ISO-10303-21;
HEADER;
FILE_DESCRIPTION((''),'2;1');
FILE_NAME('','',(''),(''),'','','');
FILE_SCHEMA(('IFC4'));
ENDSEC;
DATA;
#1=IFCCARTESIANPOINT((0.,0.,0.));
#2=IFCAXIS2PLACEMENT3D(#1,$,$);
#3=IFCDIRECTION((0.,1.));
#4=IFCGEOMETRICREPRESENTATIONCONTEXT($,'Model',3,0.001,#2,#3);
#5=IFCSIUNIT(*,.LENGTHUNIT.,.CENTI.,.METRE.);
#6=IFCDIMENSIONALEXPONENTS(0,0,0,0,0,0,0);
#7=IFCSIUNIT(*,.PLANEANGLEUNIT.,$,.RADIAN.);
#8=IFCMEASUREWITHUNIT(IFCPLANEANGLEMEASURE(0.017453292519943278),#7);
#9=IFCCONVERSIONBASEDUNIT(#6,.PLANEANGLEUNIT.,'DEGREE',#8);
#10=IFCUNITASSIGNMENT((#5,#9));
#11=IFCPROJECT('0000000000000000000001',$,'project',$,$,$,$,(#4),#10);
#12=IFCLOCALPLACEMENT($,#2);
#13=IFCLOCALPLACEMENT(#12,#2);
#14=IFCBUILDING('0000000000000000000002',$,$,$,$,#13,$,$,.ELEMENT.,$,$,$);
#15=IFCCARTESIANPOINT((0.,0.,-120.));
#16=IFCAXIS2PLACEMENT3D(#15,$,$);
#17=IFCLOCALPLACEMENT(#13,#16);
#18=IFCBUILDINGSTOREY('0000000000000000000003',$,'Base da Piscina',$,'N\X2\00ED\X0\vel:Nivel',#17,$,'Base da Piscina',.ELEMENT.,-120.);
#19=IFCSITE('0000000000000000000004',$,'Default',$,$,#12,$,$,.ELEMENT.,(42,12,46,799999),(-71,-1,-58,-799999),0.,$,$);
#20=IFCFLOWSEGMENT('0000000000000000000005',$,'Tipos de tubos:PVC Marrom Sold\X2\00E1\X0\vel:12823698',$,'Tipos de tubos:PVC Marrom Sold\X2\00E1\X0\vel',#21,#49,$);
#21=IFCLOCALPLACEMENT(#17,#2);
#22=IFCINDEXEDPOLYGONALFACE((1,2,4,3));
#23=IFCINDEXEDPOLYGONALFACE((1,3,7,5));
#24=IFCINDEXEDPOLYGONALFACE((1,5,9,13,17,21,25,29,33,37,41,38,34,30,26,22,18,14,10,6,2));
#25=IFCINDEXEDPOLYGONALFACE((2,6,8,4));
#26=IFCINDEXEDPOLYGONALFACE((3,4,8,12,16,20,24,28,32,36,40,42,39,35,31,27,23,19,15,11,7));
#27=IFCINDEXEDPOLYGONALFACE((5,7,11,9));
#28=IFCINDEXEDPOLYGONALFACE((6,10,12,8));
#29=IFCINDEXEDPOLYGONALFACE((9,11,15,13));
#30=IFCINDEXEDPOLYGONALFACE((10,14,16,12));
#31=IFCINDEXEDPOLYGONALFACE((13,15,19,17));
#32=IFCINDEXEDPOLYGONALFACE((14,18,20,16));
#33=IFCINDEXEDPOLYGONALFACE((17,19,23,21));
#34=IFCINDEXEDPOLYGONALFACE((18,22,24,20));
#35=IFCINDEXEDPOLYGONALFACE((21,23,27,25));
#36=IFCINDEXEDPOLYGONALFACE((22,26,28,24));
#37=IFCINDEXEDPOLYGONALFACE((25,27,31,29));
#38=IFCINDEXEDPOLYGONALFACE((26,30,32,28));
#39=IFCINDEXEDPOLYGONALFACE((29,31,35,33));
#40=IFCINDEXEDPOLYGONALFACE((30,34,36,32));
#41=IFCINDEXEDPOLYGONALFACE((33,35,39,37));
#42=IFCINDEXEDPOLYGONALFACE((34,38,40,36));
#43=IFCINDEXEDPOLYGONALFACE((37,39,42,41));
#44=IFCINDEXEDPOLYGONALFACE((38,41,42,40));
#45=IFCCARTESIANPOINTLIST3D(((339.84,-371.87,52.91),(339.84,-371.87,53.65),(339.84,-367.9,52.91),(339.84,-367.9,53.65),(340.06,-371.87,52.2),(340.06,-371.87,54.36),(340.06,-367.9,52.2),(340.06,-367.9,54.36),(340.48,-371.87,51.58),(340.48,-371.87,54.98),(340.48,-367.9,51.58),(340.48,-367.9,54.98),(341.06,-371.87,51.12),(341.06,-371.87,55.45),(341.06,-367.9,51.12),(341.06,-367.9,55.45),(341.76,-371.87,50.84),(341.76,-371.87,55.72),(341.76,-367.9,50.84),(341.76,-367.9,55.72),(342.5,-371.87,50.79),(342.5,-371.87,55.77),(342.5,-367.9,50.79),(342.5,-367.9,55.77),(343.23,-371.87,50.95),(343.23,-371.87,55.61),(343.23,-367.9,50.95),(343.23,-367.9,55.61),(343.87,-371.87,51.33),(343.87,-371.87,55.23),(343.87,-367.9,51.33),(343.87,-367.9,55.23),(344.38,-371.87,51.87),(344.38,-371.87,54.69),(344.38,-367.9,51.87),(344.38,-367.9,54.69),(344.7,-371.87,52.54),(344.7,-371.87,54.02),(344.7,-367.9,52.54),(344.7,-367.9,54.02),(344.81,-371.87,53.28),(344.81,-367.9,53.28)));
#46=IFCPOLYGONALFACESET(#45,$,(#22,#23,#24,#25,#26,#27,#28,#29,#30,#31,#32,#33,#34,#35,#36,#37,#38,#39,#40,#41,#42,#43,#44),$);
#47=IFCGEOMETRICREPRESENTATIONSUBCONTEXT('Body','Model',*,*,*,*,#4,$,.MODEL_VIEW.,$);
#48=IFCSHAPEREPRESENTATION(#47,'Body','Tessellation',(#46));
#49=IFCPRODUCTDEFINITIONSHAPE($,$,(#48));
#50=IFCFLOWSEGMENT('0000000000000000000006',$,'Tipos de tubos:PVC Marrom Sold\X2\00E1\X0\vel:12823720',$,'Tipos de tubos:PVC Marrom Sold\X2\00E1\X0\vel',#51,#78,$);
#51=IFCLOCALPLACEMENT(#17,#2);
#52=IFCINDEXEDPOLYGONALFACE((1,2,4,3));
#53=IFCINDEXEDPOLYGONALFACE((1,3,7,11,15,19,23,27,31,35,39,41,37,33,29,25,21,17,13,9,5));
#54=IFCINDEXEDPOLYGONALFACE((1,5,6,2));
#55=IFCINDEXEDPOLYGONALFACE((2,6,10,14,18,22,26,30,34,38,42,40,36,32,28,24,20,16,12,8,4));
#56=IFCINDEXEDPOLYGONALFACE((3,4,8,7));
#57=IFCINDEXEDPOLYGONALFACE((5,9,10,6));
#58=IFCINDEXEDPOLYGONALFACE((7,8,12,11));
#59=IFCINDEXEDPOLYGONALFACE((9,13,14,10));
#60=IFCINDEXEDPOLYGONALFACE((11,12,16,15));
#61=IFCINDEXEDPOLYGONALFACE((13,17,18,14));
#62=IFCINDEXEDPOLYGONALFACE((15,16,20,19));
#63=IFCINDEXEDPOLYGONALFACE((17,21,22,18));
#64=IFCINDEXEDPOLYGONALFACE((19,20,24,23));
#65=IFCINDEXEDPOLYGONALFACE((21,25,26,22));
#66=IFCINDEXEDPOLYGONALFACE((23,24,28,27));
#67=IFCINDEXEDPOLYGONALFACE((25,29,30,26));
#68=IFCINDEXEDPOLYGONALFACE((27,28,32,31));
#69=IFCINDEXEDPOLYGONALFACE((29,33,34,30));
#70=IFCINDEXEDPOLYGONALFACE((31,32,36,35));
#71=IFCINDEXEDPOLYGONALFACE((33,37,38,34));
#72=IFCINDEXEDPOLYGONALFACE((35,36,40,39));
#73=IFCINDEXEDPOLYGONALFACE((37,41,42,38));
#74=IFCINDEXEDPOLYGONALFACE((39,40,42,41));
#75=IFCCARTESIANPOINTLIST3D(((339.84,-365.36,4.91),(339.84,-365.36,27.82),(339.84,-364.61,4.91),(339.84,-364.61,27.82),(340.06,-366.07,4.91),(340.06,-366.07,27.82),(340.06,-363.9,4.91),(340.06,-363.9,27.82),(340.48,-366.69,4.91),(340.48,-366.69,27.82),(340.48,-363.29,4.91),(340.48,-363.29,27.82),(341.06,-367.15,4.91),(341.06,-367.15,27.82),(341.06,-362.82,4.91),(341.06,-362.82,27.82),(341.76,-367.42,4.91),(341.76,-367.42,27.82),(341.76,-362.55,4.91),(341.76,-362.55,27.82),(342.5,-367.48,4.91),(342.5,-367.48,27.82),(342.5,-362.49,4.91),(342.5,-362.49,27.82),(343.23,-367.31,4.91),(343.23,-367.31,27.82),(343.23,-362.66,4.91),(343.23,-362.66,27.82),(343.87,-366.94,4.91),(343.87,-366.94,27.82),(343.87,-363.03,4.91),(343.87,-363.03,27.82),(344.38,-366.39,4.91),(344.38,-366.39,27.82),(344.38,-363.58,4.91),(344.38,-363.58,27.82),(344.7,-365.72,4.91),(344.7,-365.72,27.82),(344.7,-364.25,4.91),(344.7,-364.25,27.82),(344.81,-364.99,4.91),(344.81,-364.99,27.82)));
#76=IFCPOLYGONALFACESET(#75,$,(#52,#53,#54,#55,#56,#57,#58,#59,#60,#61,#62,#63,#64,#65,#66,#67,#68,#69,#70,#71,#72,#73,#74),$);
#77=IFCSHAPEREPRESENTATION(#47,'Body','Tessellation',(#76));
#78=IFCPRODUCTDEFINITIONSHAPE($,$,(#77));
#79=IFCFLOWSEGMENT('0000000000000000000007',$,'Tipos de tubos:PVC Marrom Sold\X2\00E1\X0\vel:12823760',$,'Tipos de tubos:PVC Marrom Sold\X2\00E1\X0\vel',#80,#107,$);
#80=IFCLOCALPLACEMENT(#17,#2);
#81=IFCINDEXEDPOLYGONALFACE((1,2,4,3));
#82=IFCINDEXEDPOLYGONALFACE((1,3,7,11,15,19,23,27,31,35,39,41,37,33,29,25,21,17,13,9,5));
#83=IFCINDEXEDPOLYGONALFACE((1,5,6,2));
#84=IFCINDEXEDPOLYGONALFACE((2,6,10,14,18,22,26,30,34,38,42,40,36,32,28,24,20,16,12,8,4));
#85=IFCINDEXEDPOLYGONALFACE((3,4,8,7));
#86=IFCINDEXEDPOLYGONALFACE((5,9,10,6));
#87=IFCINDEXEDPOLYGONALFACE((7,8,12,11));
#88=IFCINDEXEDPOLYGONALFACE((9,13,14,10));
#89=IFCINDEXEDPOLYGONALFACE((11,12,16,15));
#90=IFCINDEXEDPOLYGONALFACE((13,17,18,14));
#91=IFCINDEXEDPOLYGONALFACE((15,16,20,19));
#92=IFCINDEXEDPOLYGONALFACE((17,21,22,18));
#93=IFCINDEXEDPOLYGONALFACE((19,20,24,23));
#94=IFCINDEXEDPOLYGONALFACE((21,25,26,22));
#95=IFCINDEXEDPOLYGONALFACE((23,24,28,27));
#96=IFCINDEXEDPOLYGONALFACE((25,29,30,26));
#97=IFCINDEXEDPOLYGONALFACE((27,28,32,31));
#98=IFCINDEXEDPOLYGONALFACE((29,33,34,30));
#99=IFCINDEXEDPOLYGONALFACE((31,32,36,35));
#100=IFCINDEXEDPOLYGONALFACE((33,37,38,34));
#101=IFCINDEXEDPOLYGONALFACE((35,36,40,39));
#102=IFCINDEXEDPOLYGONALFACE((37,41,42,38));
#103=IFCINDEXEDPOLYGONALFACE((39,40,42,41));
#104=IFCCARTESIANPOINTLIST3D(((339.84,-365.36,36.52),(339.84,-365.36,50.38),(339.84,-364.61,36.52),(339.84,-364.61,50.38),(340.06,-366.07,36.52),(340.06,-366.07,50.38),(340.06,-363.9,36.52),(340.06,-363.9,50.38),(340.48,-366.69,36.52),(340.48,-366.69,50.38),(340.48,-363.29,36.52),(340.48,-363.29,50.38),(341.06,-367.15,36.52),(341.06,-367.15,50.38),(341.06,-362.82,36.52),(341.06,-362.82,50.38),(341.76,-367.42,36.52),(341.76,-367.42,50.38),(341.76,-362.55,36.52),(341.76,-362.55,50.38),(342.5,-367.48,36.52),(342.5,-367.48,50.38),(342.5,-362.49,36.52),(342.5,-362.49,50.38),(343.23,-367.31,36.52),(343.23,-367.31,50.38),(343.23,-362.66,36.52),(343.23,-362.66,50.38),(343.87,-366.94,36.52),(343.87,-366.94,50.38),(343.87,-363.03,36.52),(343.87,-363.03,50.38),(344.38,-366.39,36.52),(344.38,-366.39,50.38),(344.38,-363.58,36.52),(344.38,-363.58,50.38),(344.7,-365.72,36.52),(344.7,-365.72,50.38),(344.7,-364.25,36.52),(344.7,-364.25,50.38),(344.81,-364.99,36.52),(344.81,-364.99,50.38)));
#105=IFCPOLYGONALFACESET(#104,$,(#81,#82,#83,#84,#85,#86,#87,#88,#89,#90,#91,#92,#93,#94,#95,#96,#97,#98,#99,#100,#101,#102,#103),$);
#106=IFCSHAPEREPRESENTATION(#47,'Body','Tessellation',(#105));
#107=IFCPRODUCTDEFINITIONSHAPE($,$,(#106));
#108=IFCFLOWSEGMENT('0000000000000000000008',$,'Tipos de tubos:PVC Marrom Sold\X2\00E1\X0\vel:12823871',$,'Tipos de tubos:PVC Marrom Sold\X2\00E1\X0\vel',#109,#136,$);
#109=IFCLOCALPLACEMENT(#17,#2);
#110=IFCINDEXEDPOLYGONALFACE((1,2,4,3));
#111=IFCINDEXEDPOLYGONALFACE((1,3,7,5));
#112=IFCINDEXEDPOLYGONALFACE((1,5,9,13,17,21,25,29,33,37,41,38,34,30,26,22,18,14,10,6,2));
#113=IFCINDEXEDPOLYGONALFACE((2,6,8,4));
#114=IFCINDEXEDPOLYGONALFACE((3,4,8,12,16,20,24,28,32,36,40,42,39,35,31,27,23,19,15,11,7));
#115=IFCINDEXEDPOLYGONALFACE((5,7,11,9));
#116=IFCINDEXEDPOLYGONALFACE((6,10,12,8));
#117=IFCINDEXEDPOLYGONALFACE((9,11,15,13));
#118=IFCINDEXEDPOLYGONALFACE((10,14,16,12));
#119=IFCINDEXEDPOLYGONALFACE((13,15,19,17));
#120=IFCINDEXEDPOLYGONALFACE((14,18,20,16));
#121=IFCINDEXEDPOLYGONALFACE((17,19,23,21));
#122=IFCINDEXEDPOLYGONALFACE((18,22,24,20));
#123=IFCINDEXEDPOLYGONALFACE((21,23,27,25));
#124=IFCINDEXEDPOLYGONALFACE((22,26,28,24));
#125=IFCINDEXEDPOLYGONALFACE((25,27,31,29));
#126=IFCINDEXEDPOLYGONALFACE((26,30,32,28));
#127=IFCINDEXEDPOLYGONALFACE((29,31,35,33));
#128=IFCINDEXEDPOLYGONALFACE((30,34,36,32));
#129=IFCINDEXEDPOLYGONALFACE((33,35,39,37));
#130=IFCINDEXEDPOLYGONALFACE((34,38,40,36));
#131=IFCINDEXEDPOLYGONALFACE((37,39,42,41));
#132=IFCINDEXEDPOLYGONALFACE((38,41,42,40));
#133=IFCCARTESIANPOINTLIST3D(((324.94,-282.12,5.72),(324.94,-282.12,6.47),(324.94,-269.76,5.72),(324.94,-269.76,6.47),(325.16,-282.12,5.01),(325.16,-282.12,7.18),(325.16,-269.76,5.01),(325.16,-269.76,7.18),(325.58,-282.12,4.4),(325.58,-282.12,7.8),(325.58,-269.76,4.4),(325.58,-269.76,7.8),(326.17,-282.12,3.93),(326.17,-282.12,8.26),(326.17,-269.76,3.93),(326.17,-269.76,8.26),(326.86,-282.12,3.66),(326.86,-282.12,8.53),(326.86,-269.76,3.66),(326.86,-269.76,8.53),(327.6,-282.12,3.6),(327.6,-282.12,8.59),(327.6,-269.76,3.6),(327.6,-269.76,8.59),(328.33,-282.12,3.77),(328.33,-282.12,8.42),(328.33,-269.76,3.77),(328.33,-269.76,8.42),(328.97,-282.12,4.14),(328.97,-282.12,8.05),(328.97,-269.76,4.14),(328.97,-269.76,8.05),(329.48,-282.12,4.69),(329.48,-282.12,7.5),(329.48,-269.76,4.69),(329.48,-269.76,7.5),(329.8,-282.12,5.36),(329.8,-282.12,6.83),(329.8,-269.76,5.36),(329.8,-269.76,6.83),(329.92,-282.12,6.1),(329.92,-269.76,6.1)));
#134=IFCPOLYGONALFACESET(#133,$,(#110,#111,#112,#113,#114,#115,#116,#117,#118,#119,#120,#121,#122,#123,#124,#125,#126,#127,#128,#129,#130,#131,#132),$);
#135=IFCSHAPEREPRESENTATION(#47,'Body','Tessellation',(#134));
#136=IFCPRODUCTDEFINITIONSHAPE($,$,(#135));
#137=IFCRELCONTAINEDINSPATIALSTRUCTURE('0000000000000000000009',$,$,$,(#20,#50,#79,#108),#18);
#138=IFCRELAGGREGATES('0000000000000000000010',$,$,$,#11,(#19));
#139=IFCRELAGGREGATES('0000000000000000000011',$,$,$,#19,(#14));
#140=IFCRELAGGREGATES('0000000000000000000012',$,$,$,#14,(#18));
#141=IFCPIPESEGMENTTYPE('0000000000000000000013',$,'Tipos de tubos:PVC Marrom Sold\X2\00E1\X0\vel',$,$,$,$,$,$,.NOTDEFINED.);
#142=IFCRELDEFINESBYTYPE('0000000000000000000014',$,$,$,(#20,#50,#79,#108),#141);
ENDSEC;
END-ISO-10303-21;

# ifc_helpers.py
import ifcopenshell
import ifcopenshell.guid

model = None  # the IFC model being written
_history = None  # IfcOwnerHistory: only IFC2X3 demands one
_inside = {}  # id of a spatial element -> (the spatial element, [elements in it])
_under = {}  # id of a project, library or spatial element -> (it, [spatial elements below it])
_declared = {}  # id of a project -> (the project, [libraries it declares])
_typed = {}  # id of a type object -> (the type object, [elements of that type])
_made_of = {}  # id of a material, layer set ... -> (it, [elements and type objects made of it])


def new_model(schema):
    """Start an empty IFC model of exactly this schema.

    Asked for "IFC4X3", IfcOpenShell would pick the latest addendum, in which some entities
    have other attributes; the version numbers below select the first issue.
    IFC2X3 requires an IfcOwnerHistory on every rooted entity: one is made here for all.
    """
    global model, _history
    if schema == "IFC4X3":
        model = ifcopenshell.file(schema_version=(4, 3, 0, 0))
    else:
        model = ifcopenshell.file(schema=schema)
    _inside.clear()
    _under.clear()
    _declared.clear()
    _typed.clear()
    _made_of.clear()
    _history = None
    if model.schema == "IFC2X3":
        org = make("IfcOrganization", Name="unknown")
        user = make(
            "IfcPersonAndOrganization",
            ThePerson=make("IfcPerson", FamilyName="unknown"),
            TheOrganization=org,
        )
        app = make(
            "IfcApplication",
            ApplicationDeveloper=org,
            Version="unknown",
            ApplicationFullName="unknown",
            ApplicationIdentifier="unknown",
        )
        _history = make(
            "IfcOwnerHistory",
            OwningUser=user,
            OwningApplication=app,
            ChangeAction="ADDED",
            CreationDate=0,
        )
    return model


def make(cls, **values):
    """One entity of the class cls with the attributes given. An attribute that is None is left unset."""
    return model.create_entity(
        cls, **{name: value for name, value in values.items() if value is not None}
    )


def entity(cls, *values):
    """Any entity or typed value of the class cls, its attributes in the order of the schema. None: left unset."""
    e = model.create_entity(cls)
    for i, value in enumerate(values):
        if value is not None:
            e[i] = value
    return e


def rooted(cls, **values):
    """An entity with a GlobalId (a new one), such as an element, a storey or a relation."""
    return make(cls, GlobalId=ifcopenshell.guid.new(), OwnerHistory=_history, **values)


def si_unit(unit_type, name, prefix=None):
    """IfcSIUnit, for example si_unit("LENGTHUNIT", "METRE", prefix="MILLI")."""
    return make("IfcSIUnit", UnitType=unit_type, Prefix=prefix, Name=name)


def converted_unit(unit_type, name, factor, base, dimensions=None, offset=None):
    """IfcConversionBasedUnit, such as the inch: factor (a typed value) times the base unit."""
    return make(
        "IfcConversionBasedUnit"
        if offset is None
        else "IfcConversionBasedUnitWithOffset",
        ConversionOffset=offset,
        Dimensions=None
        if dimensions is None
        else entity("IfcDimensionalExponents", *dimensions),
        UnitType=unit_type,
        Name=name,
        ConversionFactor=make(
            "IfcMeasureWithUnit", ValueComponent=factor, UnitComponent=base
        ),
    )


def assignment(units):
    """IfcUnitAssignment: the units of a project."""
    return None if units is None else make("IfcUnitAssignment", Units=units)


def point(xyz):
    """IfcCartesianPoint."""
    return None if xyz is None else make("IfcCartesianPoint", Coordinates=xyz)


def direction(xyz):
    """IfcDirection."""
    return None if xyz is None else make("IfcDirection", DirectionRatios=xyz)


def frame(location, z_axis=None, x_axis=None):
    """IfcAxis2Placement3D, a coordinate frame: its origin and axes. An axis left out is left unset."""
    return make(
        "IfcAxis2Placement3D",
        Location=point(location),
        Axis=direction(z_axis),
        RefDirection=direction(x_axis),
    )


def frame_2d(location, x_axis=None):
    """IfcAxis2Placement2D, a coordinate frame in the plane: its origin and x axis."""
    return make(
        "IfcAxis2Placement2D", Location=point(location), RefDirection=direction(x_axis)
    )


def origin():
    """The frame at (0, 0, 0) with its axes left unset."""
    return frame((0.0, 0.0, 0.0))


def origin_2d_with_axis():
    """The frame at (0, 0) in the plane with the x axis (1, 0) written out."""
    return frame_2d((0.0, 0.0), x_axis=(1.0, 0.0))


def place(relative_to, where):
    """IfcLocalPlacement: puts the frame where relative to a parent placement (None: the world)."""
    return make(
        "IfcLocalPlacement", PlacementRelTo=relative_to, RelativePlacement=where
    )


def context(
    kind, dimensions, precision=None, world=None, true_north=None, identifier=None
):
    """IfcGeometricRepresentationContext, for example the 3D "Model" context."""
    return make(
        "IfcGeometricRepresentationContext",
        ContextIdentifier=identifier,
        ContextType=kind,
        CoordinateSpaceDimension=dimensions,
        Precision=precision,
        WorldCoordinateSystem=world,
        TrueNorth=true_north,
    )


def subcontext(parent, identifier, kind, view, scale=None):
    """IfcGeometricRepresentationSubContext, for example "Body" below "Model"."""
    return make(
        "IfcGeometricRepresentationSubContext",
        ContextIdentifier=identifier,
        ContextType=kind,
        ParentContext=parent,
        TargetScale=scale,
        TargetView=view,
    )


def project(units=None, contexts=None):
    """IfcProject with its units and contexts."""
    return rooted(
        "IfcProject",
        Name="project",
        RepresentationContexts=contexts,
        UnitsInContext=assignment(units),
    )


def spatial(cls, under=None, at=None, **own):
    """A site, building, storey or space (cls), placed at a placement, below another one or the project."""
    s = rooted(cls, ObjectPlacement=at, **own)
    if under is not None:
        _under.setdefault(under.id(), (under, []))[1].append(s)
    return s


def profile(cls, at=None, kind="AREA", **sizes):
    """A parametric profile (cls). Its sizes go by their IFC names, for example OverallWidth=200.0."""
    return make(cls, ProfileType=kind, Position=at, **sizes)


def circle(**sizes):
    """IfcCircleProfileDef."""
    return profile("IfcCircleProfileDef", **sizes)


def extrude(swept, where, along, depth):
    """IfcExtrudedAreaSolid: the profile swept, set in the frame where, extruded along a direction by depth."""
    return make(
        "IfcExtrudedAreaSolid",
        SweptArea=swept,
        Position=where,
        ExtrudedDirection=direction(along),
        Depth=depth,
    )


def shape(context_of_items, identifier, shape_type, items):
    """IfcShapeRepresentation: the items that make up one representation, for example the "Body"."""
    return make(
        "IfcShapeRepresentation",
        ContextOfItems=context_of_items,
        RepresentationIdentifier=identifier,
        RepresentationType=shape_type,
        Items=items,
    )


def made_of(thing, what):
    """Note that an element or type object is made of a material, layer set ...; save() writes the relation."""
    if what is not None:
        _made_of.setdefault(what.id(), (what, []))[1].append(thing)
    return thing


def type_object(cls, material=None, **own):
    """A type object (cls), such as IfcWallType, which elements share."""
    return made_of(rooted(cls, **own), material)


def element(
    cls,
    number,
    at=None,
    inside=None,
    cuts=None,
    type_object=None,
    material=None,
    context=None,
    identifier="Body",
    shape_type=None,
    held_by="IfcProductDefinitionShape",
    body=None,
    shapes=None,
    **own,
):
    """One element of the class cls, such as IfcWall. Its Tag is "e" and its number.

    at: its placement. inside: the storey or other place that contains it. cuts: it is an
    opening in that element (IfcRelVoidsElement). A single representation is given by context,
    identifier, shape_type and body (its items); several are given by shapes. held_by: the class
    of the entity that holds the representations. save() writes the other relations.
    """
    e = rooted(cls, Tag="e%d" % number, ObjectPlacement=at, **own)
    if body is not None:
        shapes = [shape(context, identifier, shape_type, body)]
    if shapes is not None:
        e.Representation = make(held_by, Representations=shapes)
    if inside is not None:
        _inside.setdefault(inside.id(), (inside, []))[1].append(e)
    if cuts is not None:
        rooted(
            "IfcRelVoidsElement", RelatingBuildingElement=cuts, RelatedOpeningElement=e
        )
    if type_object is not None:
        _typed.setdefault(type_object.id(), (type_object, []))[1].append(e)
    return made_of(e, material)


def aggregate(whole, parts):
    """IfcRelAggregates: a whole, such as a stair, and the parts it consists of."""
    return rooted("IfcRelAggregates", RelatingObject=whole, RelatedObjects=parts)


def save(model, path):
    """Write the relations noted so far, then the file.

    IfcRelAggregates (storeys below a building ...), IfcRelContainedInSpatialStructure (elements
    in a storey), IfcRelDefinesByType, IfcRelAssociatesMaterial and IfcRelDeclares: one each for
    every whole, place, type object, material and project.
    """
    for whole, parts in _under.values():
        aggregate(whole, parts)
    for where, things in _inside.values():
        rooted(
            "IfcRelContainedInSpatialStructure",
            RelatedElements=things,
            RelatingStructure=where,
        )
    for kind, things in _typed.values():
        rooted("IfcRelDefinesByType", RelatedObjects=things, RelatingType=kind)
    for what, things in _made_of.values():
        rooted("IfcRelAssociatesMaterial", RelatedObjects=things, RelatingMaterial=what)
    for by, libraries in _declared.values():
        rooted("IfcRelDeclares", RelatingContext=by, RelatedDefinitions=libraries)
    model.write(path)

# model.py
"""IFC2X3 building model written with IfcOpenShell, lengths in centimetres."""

from ifc_helpers import new_model, entity, si_unit, converted_unit, direction, frame, origin, origin_2d_with_axis, place, context, subcontext, project, spatial, circle, extrude, type_object, element, save


model = new_model("IFC2X3")

# Units and contexts
model_context = context("Model", 3, precision=0.001, world=origin(), true_north=direction((0.0, 1.0)))
body_context = subcontext(model_context, "Body", "Model", "MODEL_VIEW")
ifc_project = project(units=[si_unit("LENGTHUNIT", "METRE", prefix="CENTI"), converted_unit("PLANEANGLEUNIT", "DEGREE", entity("IfcPlaneAngleMeasure", 0.017453292519943278), si_unit("PLANEANGLEUNIT", "RADIAN"), dimensions=[0, 0, 0, 0, 0, 0, 0])], contexts=[model_context])

# Site, building, storey
site_placement = place(None, origin())
site = spatial("IfcSite", under=ifc_project, at=site_placement, Name="Default", CompositionType="ELEMENT", RefLatitude=(42, 12, 46, 799999), RefLongitude=(-71, -1, -58, -799999), RefElevation=0.0)
building_placement = place(site_placement, origin())
building = spatial("IfcBuilding", under=site, at=building_placement, CompositionType="ELEMENT")
storey_placement = place(building_placement, frame((0.0, 0.0, -120.0)))
storey = spatial("IfcBuildingStorey", under=building, at=storey_placement, Name="Base da Piscina", ObjectType="Nível:Nivel", LongName="Base da Piscina", CompositionType="ELEMENT", Elevation=-120.0)

# Flow segments
pipe_segment_type = type_object("IfcPipeSegmentType", Name="Tipos de tubos:PVC Marrom Soldável", PredefinedType="NOTDEFINED")
flow_segment_1_placement = place(storey_placement, origin())
element("IfcFlowSegment", 1, at=flow_segment_1_placement, inside=storey, type_object=pipe_segment_type, Name="Tipos de tubos:PVC Marrom Soldável:12823698", ObjectType="Tipos de tubos:PVC Marrom Soldável", context=body_context, shape_type="SweptSolid", body=[
    extrude(circle(Radius=2.5, at=origin_2d_with_axis()), frame((342.31, -371.87, 53.28), z_axis=(0.0, 1.0, 0.0), x_axis=(1.0, 0.0, 0.0)), (0.0, 0.0, 1.0), 3.97),
])
flow_segment_2_placement = place(storey_placement, origin())
element("IfcFlowSegment", 2, at=flow_segment_2_placement, inside=storey, type_object=pipe_segment_type, Name="Tipos de tubos:PVC Marrom Soldável:12823720", ObjectType="Tipos de tubos:PVC Marrom Soldável", context=body_context, shape_type="SweptSolid", body=[
    extrude(circle(Radius=2.5, at=origin_2d_with_axis()), frame((342.31, -364.99, 4.91)), (0.0, 0.0, 1.0), 22.91),
])
flow_segment_3_placement = place(storey_placement, origin())
element("IfcFlowSegment", 3, at=flow_segment_3_placement, inside=storey, type_object=pipe_segment_type, Name="Tipos de tubos:PVC Marrom Soldável:12823760", ObjectType="Tipos de tubos:PVC Marrom Soldável", context=body_context, shape_type="SweptSolid", body=[
    extrude(circle(Radius=2.5, at=origin_2d_with_axis()), frame((342.31, -364.99, 36.52)), (0.0, 0.0, 1.0), 13.85),
])
flow_segment_4_placement = place(storey_placement, origin())
element("IfcFlowSegment", 4, at=flow_segment_4_placement, inside=storey, type_object=pipe_segment_type, Name="Tipos de tubos:PVC Marrom Soldável:12823871", ObjectType="Tipos de tubos:PVC Marrom Soldável", context=body_context, shape_type="SweptSolid", body=[
    extrude(circle(Radius=2.5, at=origin_2d_with_axis()), frame((327.42, -282.12, 6.1), z_axis=(0.0, 1.0, 0.0), x_axis=(1.0, 0.0, 0.0)), (0.0, 0.0, 1.0), 12.36),
])

save(model, "model.ifc")
